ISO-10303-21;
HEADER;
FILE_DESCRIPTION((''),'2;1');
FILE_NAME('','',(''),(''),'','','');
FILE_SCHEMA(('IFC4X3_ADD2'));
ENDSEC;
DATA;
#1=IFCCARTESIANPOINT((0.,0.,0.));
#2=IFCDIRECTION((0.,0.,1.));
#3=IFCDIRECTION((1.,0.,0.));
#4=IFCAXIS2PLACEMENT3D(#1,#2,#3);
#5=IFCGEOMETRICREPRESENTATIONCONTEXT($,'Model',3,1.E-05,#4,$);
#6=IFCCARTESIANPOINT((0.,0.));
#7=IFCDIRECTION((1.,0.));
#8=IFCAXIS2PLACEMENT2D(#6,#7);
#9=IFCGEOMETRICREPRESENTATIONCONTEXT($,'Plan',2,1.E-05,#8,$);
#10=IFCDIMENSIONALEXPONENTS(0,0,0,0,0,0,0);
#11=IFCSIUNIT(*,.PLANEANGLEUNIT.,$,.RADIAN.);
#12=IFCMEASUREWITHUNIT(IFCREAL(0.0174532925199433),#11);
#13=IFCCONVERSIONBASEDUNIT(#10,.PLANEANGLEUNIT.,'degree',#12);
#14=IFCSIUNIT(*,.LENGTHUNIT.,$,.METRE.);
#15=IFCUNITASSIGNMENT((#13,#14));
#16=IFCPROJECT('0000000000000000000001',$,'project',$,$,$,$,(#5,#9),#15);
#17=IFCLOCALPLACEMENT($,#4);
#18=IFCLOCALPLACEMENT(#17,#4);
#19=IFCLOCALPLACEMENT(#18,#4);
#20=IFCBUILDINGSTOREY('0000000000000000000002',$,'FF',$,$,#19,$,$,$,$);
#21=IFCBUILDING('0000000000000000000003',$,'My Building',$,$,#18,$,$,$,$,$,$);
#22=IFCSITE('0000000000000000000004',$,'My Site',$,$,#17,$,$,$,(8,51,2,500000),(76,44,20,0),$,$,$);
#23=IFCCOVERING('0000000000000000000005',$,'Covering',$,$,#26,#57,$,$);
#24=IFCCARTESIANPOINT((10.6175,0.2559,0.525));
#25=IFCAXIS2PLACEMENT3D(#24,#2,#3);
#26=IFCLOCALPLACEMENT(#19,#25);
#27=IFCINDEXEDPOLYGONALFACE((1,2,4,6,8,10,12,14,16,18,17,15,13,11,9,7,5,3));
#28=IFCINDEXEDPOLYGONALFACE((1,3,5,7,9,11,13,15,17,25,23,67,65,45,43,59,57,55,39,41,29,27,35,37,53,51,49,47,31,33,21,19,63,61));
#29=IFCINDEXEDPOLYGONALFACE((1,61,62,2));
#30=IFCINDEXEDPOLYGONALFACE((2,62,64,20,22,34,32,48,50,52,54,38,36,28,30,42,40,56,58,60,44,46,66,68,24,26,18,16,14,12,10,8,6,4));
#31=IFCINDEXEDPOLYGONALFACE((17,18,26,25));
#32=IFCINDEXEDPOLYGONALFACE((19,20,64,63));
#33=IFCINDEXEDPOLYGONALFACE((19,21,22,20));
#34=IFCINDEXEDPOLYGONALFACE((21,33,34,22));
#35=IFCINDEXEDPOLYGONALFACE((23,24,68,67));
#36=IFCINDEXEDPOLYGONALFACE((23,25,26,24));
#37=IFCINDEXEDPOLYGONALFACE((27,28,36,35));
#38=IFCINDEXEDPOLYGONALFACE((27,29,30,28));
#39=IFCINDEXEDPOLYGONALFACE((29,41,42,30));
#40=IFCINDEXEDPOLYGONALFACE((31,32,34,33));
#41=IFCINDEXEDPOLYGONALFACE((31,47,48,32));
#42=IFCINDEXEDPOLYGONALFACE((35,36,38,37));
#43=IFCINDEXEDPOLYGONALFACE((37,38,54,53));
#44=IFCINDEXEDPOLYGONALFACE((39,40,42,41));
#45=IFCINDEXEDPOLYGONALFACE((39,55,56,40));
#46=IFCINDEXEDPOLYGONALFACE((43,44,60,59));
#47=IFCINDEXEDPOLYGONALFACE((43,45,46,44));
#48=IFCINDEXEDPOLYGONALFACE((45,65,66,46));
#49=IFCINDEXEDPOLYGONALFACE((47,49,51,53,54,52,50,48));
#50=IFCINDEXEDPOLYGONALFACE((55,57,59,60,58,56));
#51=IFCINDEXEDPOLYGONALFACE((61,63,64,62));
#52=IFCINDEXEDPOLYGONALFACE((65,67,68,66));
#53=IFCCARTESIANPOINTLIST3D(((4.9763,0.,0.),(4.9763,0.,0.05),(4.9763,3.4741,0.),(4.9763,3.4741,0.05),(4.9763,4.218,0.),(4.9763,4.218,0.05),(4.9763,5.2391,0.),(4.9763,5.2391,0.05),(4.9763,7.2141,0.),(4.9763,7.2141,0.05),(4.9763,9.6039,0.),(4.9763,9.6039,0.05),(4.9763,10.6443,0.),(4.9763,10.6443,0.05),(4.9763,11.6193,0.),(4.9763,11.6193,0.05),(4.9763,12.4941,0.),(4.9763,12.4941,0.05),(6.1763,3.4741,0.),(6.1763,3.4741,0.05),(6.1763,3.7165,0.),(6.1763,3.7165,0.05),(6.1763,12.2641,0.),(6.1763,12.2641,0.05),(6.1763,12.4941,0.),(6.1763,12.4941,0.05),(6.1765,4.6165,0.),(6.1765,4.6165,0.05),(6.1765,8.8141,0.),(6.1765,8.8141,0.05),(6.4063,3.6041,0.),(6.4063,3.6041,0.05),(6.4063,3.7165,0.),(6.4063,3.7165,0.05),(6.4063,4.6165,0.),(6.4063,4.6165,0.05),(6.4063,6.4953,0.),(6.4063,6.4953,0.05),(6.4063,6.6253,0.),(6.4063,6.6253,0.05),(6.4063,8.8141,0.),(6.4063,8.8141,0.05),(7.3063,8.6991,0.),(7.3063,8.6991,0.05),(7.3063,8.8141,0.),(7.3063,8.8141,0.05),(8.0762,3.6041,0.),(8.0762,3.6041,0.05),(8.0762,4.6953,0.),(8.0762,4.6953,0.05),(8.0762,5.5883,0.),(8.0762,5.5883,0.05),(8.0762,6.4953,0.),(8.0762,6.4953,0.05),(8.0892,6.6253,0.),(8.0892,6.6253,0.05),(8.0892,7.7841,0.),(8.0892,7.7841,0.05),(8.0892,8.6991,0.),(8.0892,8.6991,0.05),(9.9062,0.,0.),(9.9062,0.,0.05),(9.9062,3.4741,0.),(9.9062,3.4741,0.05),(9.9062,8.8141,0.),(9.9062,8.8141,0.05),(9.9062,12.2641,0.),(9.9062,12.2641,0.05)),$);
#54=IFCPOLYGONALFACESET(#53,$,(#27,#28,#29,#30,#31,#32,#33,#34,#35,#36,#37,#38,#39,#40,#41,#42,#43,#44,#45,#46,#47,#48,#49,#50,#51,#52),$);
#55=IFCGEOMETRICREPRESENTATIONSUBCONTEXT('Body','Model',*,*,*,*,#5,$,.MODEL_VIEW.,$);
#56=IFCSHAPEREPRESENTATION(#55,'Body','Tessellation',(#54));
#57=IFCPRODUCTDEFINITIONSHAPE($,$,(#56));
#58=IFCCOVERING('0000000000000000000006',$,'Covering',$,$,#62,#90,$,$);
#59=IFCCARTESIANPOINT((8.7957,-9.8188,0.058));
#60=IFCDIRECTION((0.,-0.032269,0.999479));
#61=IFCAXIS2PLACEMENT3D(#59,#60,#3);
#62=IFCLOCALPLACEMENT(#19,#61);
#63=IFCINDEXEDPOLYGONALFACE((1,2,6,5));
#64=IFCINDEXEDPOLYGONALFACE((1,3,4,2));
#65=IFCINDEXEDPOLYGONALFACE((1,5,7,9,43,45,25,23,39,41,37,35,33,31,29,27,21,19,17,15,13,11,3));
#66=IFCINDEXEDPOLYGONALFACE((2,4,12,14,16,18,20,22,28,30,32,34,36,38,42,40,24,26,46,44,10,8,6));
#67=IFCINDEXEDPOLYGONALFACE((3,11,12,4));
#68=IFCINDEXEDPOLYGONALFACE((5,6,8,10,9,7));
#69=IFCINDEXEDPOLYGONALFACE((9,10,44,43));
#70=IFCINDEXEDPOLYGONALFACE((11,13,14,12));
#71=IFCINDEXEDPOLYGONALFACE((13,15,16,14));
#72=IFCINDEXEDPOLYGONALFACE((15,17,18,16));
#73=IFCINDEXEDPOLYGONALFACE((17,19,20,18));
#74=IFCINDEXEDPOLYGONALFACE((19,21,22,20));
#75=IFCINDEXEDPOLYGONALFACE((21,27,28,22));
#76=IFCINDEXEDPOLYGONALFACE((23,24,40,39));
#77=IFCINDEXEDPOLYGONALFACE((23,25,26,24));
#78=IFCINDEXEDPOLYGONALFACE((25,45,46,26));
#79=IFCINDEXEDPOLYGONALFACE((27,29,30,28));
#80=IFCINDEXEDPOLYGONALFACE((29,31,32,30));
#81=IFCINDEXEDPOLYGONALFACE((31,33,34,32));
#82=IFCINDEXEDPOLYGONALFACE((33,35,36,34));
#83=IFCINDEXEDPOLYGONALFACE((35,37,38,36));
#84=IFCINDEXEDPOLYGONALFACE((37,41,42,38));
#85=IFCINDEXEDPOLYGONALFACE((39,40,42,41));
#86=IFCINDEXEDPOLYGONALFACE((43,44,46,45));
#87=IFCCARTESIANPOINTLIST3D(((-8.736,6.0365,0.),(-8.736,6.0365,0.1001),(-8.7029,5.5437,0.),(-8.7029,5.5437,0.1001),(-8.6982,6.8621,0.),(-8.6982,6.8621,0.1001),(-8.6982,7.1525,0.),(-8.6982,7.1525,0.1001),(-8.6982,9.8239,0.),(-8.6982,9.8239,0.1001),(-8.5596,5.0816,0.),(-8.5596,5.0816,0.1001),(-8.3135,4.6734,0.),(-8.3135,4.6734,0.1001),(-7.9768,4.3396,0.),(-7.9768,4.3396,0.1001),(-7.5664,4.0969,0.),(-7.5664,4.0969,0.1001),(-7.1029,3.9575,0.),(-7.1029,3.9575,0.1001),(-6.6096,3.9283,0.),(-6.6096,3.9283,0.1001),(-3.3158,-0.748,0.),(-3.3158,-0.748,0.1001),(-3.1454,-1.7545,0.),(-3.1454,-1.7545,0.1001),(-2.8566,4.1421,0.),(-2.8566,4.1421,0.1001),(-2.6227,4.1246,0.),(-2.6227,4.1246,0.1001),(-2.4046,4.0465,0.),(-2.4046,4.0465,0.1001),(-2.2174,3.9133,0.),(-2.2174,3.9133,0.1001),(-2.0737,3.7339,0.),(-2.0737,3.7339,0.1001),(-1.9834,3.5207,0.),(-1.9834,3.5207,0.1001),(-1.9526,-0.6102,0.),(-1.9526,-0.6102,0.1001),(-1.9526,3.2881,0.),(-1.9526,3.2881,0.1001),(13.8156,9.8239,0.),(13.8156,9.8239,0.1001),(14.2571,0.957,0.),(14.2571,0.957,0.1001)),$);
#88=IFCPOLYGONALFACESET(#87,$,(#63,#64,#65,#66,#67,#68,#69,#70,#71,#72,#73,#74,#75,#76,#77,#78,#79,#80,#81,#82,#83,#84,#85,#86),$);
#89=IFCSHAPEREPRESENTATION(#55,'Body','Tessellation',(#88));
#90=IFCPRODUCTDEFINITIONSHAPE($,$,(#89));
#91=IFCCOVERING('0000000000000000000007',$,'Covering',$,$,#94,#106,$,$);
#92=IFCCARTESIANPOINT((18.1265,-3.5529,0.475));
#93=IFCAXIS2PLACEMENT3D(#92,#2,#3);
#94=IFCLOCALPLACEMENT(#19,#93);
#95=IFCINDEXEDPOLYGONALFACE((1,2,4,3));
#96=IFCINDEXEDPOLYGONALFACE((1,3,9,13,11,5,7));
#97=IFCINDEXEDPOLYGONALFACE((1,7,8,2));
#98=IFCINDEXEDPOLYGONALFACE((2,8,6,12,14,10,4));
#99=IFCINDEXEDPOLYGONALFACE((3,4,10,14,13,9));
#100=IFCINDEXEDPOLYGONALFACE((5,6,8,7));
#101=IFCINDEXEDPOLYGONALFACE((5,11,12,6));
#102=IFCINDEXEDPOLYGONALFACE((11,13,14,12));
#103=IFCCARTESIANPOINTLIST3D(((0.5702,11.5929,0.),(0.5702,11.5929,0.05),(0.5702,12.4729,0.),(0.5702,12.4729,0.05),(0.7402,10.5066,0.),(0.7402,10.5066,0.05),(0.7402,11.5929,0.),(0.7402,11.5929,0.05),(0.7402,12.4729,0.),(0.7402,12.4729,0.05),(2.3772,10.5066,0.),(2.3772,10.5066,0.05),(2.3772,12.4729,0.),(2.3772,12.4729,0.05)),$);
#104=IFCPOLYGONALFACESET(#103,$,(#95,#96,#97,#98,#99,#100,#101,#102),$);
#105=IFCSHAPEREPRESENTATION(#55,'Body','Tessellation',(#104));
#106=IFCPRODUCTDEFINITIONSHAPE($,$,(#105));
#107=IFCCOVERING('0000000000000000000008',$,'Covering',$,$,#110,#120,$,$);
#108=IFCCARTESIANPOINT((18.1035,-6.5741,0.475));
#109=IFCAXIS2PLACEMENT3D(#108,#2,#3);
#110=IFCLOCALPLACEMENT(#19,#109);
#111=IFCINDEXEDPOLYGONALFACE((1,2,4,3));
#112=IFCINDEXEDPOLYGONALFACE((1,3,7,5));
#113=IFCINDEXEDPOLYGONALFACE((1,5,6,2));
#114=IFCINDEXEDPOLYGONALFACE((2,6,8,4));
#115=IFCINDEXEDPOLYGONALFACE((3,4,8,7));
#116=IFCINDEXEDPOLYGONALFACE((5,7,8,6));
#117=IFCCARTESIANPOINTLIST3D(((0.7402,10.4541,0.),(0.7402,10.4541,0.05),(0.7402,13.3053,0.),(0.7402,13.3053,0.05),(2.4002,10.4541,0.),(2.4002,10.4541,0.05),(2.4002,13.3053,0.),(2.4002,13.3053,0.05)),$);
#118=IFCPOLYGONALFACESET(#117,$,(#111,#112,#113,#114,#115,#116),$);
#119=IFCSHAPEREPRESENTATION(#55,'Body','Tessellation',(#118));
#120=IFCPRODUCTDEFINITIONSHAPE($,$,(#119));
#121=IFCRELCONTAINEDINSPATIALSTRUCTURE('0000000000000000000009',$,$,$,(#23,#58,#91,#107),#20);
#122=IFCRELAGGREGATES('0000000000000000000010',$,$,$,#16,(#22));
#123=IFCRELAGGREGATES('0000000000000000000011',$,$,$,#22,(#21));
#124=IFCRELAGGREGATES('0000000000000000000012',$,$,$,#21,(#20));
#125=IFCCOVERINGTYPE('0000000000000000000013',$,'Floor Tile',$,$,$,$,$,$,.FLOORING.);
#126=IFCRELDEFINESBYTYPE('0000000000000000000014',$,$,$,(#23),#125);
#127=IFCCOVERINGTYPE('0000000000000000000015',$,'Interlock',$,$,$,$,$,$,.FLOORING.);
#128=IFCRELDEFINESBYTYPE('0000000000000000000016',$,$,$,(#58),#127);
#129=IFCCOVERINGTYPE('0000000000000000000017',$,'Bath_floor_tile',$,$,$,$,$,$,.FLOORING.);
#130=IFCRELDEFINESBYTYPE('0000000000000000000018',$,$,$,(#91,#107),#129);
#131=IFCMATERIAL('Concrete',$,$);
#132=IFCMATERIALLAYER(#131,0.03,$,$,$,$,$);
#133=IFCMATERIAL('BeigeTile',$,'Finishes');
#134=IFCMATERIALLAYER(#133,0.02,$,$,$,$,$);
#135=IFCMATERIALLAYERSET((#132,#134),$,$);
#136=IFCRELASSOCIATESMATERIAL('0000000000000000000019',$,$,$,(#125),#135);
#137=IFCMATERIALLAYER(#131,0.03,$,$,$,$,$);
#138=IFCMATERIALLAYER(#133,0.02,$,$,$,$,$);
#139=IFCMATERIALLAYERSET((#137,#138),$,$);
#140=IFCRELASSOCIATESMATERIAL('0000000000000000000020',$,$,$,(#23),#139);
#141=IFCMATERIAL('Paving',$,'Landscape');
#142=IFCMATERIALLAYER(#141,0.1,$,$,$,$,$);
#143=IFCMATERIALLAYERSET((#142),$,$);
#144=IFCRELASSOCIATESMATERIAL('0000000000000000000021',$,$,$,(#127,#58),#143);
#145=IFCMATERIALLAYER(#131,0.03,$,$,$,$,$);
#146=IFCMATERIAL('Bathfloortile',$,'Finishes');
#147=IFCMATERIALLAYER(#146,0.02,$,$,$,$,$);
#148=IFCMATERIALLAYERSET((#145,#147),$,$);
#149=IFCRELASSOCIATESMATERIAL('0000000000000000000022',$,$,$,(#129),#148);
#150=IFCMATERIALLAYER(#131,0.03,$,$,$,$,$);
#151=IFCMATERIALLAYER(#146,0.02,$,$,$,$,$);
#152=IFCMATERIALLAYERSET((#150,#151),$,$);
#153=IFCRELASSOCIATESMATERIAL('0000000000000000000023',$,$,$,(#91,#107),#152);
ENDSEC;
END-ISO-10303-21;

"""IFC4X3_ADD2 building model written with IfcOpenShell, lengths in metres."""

from ifc_helpers import new_model, entity, si_unit, converted_unit, frame, origin_with_axes, origin_2d_with_axis, place, context, subcontext, project, spatial, indexed_curve, outline, extrude, material, layer, layer_set, layer_usage, type_object, element, save


model = new_model("IFC4X3_ADD2")

# Units and contexts
model_context = context("Model", 3, precision=1e-05, world=origin_with_axes())
plan_context = context("Plan", 2, precision=1e-05, world=origin_2d_with_axis())
body_context = subcontext(model_context, "Body", "Model", "MODEL_VIEW")
ifc_project = project(units=[converted_unit("PLANEANGLEUNIT", "degree", entity("IfcReal", 0.0174532925199433), si_unit("PLANEANGLEUNIT", "RADIAN"), dimensions=[0, 0, 0, 0, 0, 0, 0]), si_unit("LENGTHUNIT", "METRE")], contexts=[model_context, plan_context])

# Site, building, storey
site_placement = place(None, origin_with_axes())
site = spatial("IfcSite", under=ifc_project, at=site_placement, Name="My Site", RefLatitude=(8, 51, 2, 500000), RefLongitude=(76, 44, 20, 0))
building_placement = place(site_placement, origin_with_axes())
building = spatial("IfcBuilding", under=site, at=building_placement, Name="My Building")
storey_placement = place(building_placement, origin_with_axes())
storey = spatial("IfcBuildingStorey", under=building, at=storey_placement, Name="FF")

# Coverings
ifc_material_1 = material(Name="Concrete")
ifc_layer_1 = layer(ifc_material_1, 0.03)
ifc_material_2 = material(Name="BeigeTile", Category="Finishes")
ifc_layer_2 = layer(ifc_material_2, 0.02)
ifc_layer_set_1 = layer_set([ifc_layer_1, ifc_layer_2])
ifc_layer_usage_1 = layer_usage(ifc_layer_set_1, "AXIS3", "POSITIVE", 0.0)
ifc_layer_3 = layer(ifc_material_1, 0.03)
ifc_layer_4 = layer(ifc_material_2, 0.02)
ifc_layer_set_2 = layer_set([ifc_layer_3, ifc_layer_4])
covering_type_1 = type_object("IfcCoveringType", Name="Floor Tile", PredefinedType="FLOORING", material=ifc_layer_set_2)
covering_1_placement = place(storey_placement, frame((10.6175, 0.2559, 0.525), z_axis=(0.0, 0.0, 1.0), x_axis=(1.0, 0.0, 0.0)))
element("IfcCovering", 1, at=covering_1_placement, inside=storey, type_object=covering_type_1, material=ifc_layer_usage_1, Name="Covering", context=body_context, shape_type="SweptSolid", body=[
    extrude(outline(indexed_curve([(8.0762, 3.6041), (6.4063, 3.6041), (6.4063, 3.7165), (6.1763, 3.7165), (6.1763, 3.4741), (9.9062, 3.4741), (9.9062, 0.0), (4.9763, 0.0), (4.9763, 3.4741), (4.9763, 4.218), (4.9763, 5.2391), (4.9763, 7.2141), (4.9763, 9.6039), (4.9763, 10.6443), (4.9763, 11.6193), (4.9763, 12.4941), (6.1763, 12.4941), (6.1763, 12.2641), (9.9062, 12.2641), (9.9062, 8.8141), (7.3063, 8.8141), (7.3063, 8.6991), (8.0892, 8.6991), (8.0892, 7.7841), (8.0892, 6.6253), (6.4063, 6.6253), (6.4063, 8.8141), (6.1765, 8.8141), (6.1765, 4.6165), (6.4063, 4.6165), (6.4063, 6.4953), (8.0762, 6.4953), (8.0762, 5.5883), (8.0762, 4.6953), (8.0762, 3.6041)])), origin_with_axes(), (0.0, 0.0, 1.0), 0.05),
])
ifc_material_3 = material(Name="Paving", Category="Landscape")
ifc_layer_5 = layer(ifc_material_3, 0.1)
ifc_layer_set_3 = layer_set([ifc_layer_5])
ifc_layer_usage_2 = layer_usage(ifc_layer_set_3, "AXIS3", "POSITIVE", 0.0)
covering_type_2 = type_object("IfcCoveringType", Name="Interlock", PredefinedType="FLOORING", material=ifc_layer_set_3)
covering_2_placement = place(storey_placement, frame((8.7957, -9.8188, 0.058), z_axis=(0.0, -0.032269, 0.999479), x_axis=(1.0, 0.0, 0.0)))
element("IfcCovering", 2, at=covering_2_placement, inside=storey, type_object=covering_type_2, material=ifc_layer_usage_2, Name="Covering", context=body_context, shape_type="SweptSolid", body=[
    extrude(outline(indexed_curve([(-2.0737, 3.7339), (-2.2174, 3.9133), (-2.4046, 4.0465), (-2.6227, 4.1246), (-2.8566, 4.1421), (-6.6096, 3.9283), (-7.1029, 3.9575), (-7.5664, 4.0969), (-7.9768, 4.3396), (-8.3135, 4.6734), (-8.5596, 5.0816), (-8.7029, 5.5437), (-8.736, 6.0365), (-8.6982, 6.8621), (-8.6982, 7.1525), (-8.6982, 9.8239), (13.8156, 9.8239), (14.2571, 0.957), (-3.1454, -1.7545), (-3.3158, -0.748), (-1.9526, -0.6102), (-1.9526, 3.2881), (-1.9834, 3.5207), (-2.0737, 3.7339)])), origin_with_axes(), (0.0, 0.0, 1.0), 0.1001),
])
ifc_layer_6 = layer(ifc_material_1, 0.03)
ifc_material_4 = material(Name="Bathfloortile", Category="Finishes")
ifc_layer_7 = layer(ifc_material_4, 0.02)
ifc_layer_set_4 = layer_set([ifc_layer_6, ifc_layer_7])
ifc_layer_usage_3 = layer_usage(ifc_layer_set_4, "AXIS3", "POSITIVE", 0.0)
ifc_layer_8 = layer(ifc_material_1, 0.03)
ifc_layer_9 = layer(ifc_material_4, 0.02)
ifc_layer_set_5 = layer_set([ifc_layer_8, ifc_layer_9])
covering_type_3 = type_object("IfcCoveringType", Name="Bath_floor_tile", PredefinedType="FLOORING", material=ifc_layer_set_5)
covering_3_placement = place(storey_placement, frame((18.1265, -3.5529, 0.475), z_axis=(0.0, 0.0, 1.0), x_axis=(1.0, 0.0, 0.0)))
element("IfcCovering", 3, at=covering_3_placement, inside=storey, type_object=covering_type_3, material=ifc_layer_usage_3, Name="Covering", context=body_context, shape_type="SweptSolid", body=[
    extrude(outline(indexed_curve([(0.7402, 11.5929), (0.5702, 11.5929), (0.5702, 12.4729), (0.7402, 12.4729), (2.3772, 12.4729), (2.3772, 10.5066), (0.7402, 10.5066), (0.7402, 11.5929)])), origin_with_axes(), (0.0, 0.0, 1.0), 0.05),
])
ifc_layer_usage_4 = layer_usage(ifc_layer_set_4, "AXIS3", "POSITIVE", 0.0)
covering_4_placement = place(storey_placement, frame((18.1035, -6.5741, 0.475), z_axis=(0.0, 0.0, 1.0), x_axis=(1.0, 0.0, 0.0)))
element("IfcCovering", 4, at=covering_4_placement, inside=storey, type_object=covering_type_3, material=ifc_layer_usage_4, Name="Covering", context=body_context, shape_type="SweptSolid", body=[
    extrude(outline(indexed_curve([(2.4002, 10.4541), (2.4002, 13.3053), (0.7402, 13.3053), (0.7402, 10.4541), (2.4002, 10.4541)])), origin_with_axes(), (0.0, 0.0, 1.0), 0.05),
])

save(model, "model.ifc")
